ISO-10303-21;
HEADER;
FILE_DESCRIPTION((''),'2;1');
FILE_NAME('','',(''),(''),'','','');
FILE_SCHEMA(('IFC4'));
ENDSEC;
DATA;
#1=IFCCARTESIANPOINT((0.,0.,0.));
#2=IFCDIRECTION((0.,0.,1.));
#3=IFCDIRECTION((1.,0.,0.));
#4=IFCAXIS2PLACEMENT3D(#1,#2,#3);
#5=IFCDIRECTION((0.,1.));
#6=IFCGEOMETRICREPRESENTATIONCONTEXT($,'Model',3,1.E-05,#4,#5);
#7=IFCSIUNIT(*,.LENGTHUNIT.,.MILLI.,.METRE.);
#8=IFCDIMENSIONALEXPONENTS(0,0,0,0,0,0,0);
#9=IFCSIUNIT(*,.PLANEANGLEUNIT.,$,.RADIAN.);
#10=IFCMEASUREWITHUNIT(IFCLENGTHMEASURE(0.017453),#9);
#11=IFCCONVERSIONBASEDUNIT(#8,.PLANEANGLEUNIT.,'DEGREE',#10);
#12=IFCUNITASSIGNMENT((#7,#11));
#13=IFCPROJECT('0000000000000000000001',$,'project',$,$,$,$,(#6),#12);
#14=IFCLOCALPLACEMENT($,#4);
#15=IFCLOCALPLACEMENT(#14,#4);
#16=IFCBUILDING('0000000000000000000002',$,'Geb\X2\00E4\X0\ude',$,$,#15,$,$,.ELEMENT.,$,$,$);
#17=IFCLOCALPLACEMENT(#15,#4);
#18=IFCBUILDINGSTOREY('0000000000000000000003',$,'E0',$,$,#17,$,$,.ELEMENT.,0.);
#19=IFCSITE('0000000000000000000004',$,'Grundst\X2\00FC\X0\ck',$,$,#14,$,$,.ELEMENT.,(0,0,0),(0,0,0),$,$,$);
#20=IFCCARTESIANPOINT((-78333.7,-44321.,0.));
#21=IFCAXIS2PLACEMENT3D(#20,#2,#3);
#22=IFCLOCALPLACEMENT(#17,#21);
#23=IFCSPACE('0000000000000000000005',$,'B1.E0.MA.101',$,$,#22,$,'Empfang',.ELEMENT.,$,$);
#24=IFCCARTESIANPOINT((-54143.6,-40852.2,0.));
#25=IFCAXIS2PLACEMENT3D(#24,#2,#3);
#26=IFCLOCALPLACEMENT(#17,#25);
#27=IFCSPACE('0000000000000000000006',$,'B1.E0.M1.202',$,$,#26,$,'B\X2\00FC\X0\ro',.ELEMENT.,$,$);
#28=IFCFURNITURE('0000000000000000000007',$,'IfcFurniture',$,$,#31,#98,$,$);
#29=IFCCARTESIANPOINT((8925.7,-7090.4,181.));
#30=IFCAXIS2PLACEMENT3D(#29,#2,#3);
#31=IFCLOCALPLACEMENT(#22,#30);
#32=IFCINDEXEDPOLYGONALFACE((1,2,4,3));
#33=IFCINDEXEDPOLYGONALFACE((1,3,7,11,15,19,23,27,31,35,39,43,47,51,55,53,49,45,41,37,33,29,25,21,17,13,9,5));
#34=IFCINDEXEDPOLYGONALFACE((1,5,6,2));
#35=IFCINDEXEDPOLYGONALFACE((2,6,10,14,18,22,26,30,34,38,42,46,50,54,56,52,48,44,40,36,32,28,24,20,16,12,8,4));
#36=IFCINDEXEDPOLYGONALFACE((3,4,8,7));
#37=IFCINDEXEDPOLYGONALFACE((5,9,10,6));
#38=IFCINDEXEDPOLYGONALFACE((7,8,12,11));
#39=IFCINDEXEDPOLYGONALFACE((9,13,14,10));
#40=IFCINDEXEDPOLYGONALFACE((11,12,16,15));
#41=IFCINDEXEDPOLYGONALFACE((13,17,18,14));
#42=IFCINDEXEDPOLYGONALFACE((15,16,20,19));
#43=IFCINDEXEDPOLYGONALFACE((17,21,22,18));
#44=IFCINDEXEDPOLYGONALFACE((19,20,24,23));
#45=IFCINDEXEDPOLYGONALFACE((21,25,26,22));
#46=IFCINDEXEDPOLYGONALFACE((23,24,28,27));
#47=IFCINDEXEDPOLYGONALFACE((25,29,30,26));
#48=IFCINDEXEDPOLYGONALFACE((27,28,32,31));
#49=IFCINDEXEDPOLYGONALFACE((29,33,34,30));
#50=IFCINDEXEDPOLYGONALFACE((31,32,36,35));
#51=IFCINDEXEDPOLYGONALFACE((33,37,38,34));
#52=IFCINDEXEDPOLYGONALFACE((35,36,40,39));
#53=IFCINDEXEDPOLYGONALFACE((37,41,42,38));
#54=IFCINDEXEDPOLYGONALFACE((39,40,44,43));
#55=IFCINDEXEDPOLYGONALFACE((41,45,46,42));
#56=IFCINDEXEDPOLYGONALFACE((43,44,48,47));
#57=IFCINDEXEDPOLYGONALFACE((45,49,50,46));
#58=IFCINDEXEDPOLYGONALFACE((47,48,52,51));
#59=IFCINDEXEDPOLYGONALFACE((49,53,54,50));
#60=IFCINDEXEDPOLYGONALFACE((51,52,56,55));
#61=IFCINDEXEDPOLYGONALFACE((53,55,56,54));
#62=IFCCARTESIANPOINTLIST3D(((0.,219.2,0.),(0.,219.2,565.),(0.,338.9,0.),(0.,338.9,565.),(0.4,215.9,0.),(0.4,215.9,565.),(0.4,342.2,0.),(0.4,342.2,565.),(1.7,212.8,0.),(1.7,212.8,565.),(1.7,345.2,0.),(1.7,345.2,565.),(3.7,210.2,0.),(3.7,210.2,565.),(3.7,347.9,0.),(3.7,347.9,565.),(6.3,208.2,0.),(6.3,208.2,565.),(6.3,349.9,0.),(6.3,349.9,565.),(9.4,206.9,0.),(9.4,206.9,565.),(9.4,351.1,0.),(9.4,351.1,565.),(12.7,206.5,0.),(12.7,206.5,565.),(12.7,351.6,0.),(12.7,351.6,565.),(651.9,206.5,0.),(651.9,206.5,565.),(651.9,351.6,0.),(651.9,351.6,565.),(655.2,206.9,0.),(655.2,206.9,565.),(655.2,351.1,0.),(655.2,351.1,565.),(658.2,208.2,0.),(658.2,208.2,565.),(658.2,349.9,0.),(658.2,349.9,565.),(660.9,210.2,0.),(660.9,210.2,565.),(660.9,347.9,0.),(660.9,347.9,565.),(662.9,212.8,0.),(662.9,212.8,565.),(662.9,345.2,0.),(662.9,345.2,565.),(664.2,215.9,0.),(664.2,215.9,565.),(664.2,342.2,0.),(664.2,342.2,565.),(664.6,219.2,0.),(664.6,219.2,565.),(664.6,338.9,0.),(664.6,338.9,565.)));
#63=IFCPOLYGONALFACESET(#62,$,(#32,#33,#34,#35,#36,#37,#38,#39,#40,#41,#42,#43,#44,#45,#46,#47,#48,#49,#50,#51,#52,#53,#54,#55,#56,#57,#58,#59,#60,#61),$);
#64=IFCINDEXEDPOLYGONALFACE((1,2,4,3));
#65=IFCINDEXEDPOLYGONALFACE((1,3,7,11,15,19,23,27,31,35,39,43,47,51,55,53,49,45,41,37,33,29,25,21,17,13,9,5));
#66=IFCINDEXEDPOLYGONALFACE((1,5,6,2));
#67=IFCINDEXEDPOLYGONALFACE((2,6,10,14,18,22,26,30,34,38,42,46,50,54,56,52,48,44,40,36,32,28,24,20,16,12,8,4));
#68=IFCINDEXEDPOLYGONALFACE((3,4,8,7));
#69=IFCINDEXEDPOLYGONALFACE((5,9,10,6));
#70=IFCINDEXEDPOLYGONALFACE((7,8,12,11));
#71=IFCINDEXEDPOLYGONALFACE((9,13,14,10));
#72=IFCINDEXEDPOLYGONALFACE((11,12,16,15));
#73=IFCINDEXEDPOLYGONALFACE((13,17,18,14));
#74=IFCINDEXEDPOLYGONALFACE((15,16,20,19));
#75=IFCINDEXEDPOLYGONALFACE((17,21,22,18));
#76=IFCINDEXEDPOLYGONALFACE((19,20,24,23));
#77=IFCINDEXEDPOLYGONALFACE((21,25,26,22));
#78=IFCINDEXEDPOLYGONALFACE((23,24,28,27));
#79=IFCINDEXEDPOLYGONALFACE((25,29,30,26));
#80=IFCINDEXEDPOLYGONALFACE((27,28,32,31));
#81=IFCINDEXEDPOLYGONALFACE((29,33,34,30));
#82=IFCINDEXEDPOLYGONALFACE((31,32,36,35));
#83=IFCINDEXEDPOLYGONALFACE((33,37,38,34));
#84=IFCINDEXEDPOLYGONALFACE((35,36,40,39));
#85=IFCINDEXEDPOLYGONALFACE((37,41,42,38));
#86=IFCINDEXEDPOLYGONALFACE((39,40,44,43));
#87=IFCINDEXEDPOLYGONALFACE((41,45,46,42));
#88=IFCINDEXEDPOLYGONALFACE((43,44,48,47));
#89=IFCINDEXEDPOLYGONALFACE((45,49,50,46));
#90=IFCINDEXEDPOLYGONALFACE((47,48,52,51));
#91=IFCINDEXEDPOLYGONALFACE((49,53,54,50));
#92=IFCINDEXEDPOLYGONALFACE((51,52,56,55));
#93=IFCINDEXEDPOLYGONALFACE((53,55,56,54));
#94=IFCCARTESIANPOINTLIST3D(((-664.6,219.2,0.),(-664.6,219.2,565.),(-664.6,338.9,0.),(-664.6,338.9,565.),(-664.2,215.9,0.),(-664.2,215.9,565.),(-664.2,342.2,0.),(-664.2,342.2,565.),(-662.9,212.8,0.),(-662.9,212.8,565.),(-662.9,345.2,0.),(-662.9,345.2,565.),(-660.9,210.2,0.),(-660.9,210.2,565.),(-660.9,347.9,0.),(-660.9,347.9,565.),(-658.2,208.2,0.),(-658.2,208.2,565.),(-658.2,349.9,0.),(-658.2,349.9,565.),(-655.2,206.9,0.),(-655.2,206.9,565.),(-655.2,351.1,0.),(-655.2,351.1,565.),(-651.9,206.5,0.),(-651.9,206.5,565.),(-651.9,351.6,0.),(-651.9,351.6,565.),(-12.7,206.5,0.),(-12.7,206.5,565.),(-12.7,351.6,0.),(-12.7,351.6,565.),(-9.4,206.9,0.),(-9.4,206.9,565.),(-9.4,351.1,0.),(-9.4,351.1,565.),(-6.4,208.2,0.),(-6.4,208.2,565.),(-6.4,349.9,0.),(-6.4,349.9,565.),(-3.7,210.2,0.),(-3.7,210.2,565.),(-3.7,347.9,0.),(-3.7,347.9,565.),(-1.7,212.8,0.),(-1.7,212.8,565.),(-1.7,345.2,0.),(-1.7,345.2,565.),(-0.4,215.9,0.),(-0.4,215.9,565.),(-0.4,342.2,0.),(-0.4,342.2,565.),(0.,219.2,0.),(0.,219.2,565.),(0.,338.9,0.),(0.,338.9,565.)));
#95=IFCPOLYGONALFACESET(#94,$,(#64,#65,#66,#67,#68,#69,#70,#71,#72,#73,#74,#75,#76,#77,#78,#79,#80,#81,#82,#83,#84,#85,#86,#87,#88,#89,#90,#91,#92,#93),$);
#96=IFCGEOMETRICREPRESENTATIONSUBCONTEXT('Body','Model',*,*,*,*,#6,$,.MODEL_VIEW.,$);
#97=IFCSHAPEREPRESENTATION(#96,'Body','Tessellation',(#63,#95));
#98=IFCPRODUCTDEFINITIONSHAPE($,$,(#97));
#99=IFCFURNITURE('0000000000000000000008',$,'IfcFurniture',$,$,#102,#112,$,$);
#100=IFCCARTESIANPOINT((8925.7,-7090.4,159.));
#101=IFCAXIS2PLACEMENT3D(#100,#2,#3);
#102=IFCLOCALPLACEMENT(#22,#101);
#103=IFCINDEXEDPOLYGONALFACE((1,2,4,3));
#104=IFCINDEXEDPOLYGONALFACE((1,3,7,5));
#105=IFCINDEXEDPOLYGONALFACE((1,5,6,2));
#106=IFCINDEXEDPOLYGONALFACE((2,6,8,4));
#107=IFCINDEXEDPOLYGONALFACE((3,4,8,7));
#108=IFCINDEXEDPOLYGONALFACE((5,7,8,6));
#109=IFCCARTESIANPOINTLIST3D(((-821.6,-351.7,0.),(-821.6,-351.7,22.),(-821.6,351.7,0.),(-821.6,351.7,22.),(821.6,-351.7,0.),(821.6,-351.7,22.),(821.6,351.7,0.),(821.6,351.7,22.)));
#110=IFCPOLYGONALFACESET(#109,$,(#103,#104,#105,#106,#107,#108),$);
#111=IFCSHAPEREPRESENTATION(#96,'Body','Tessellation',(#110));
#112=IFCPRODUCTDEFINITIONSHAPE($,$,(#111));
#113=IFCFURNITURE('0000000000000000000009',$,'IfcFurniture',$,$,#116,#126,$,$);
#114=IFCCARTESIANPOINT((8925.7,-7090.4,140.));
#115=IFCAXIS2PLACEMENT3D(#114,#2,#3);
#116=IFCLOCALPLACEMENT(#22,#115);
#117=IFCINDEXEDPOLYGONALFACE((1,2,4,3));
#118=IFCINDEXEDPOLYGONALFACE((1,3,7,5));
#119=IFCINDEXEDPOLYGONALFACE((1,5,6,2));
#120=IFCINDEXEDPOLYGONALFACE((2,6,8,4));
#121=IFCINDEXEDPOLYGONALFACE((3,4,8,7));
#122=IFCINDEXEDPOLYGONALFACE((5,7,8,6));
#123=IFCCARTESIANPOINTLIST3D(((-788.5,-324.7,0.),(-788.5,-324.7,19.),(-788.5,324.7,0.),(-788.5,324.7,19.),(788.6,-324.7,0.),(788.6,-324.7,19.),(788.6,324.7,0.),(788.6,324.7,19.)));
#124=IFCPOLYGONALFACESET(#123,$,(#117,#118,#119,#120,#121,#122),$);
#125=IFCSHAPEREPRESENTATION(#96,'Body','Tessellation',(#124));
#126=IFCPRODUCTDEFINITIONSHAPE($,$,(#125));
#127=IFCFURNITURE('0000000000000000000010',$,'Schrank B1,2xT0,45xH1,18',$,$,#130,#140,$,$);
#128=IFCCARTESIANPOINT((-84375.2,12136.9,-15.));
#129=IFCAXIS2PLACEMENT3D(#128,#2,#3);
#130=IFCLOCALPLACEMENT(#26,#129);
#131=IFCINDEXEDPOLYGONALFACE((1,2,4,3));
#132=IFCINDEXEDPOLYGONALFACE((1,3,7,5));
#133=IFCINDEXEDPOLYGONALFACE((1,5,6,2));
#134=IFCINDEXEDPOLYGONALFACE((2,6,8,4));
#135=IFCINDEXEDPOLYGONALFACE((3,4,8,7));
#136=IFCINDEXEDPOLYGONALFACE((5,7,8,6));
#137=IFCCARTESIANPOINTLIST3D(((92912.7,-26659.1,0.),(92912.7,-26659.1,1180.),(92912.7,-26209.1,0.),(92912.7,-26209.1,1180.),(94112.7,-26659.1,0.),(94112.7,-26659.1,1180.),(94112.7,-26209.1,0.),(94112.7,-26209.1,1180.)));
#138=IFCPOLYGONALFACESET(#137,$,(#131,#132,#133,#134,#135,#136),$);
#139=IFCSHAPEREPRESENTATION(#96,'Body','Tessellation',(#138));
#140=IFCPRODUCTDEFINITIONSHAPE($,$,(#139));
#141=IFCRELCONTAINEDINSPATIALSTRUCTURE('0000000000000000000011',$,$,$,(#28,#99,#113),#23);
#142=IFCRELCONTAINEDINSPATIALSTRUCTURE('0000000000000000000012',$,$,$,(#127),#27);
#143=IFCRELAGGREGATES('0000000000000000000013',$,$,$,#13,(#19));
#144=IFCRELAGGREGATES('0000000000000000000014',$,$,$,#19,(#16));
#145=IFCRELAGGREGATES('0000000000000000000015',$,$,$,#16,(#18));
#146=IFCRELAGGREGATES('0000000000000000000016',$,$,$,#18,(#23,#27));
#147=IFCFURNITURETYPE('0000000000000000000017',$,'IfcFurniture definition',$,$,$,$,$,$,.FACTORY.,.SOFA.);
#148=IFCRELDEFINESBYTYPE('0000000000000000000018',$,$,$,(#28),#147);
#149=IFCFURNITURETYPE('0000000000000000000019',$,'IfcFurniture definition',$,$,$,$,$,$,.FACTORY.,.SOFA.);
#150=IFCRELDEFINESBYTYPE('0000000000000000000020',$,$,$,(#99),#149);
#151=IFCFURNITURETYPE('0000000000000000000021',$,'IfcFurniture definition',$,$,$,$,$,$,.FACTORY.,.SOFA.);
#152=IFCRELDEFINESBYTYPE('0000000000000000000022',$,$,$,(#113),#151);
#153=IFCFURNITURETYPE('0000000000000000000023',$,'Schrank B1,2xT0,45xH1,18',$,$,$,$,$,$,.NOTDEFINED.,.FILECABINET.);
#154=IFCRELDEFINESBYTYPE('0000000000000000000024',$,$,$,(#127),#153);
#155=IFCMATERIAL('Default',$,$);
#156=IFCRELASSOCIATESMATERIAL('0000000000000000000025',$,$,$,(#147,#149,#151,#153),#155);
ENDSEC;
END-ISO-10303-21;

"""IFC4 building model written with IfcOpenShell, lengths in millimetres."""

from ifc_helpers import new_model, entity, si_unit, converted_unit, direction, frame, origin_with_axes, place, context, subcontext, project, spatial, line, arc, indexed_curve, outline, extrude, material, type_object, element, save


model = new_model("IFC4")

# Units and contexts
model_context = context("Model", 3, precision=1e-05, world=origin_with_axes(), true_north=direction((0.0, 1.0)))
body_context = subcontext(model_context, "Body", "Model", "MODEL_VIEW")
ifc_project = project(units=[si_unit("LENGTHUNIT", "METRE", prefix="MILLI"), converted_unit("PLANEANGLEUNIT", "DEGREE", entity("IfcLengthMeasure", 0.017453), si_unit("PLANEANGLEUNIT", "RADIAN"), dimensions=[0, 0, 0, 0, 0, 0, 0])], contexts=[model_context])

# Site, building, storey
site_placement = place(None, origin_with_axes())
site = spatial("IfcSite", under=ifc_project, at=site_placement, Name="Grundstück", CompositionType="ELEMENT", RefLatitude=(0, 0, 0), RefLongitude=(0, 0, 0))
building_placement = place(site_placement, origin_with_axes())
building = spatial("IfcBuilding", under=site, at=building_placement, Name="Gebäude", CompositionType="ELEMENT")
storey_placement = place(building_placement, origin_with_axes())
storey = spatial("IfcBuildingStorey", under=building, at=storey_placement, Name="E0", CompositionType="ELEMENT", Elevation=0.0)

# Shared definitions
space_1_placement = place(storey_placement, frame((-78333.7, -44321.0, 0.0), z_axis=(0.0, 0.0, 1.0), x_axis=(1.0, 0.0, 0.0)))
space_1 = spatial("IfcSpace", under=storey, at=space_1_placement, Name="B1.E0.MA.101", LongName="Empfang", CompositionType="ELEMENT")

# Furniture
ifc_material_1 = material(Name="Default")
furniture_type_1 = type_object("IfcFurnitureType", Name="IfcFurniture definition", AssemblyPlace="FACTORY", PredefinedType="SOFA", material=ifc_material_1)
furniture_1_placement = place(space_1_placement, frame((8925.7, -7090.4, 181.0), z_axis=(0.0, 0.0, 1.0), x_axis=(1.0, 0.0, 0.0)))
element("IfcFurniture", 1, at=furniture_1_placement, inside=space_1, type_object=furniture_type_1, Name="IfcFurniture", context=body_context, shape_type="SweptSolid", body=[
    extrude(outline(indexed_curve([(651.9, 351.6), (660.9, 347.9), (664.6, 338.9), (664.6, 219.2), (660.9, 210.2), (651.9, 206.5), (12.7, 206.5), (3.7, 210.2), (0.0, 219.2), (0.0, 338.9), (3.7, 347.9), (12.7, 351.6)], segments=[arc(1, 2, 3), line(3, 4), arc(4, 5, 6), line(6, 7), arc(7, 8, 9), line(9, 10), arc(10, 11, 12), line(12, 1)])), origin_with_axes(), (0.0, 0.0, 1.0), 565.0),
    extrude(outline(indexed_curve([(-651.9, 351.6), (-660.9, 347.9), (-664.6, 338.9), (-664.6, 219.2), (-660.9, 210.2), (-651.9, 206.5), (-12.7, 206.5), (-3.7, 210.2), (0.0, 219.2), (0.0, 338.9), (-3.7, 347.9), (-12.7, 351.6)], segments=[arc(1, 2, 3), line(3, 4), arc(4, 5, 6), line(6, 7), arc(7, 8, 9), line(9, 10), arc(10, 11, 12), line(12, 1)])), origin_with_axes(), (0.0, 0.0, 1.0), 565.0),
])
furniture_type_2 = type_object("IfcFurnitureType", Name="IfcFurniture definition", AssemblyPlace="FACTORY", PredefinedType="SOFA", material=ifc_material_1)
furniture_2_placement = place(space_1_placement, frame((8925.7, -7090.4, 159.0), z_axis=(0.0, 0.0, 1.0), x_axis=(1.0, 0.0, 0.0)))
element("IfcFurniture", 2, at=furniture_2_placement, inside=space_1, type_object=furniture_type_2, Name="IfcFurniture", context=body_context, shape_type="SweptSolid", body=[
    extrude(outline(indexed_curve([(-821.6, -351.7), (-821.6, 351.7), (821.6, 351.7), (821.6, -351.7)], segments=[line(1, 2), line(2, 3), line(3, 4), line(4, 1)])), origin_with_axes(), (0.0, 0.0, 1.0), 22.0),
])
furniture_type_3 = type_object("IfcFurnitureType", Name="IfcFurniture definition", AssemblyPlace="FACTORY", PredefinedType="SOFA", material=ifc_material_1)
furniture_3_placement = place(space_1_placement, frame((8925.7, -7090.4, 140.0), z_axis=(0.0, 0.0, 1.0), x_axis=(1.0, 0.0, 0.0)))
element("IfcFurniture", 3, at=furniture_3_placement, inside=space_1, type_object=furniture_type_3, Name="IfcFurniture", context=body_context, shape_type="SweptSolid", body=[
    extrude(outline(indexed_curve([(-788.5, -324.7), (-788.5, 324.7), (788.6, 324.7), (788.6, -324.7)], segments=[line(1, 2), line(2, 3), line(3, 4), line(4, 1)])), origin_with_axes(), (0.0, 0.0, 1.0), 19.0),
])

# Shared definitions
space_2_placement = place(storey_placement, frame((-54143.6, -40852.2, 0.0), z_axis=(0.0, 0.0, 1.0), x_axis=(1.0, 0.0, 0.0)))
space_2 = spatial("IfcSpace", under=storey, at=space_2_placement, Name="B1.E0.M1.202", LongName="Büro", CompositionType="ELEMENT")

# Furniture
furniture_type_4 = type_object("IfcFurnitureType", Name="Schrank B1,2xT0,45xH1,18", AssemblyPlace="NOTDEFINED", PredefinedType="FILECABINET", material=ifc_material_1)
furniture_4_placement = place(space_2_placement, frame((-84375.2, 12136.9, -15.0), z_axis=(0.0, 0.0, 1.0), x_axis=(1.0, 0.0, 0.0)))
element("IfcFurniture", 4, at=furniture_4_placement, inside=space_2, type_object=furniture_type_4, Name="Schrank B1,2xT0,45xH1,18", context=body_context, shape_type="SweptSolid", body=[
    extrude(outline(indexed_curve([(92912.7, -26659.1), (94112.7, -26659.1), (94112.7, -26209.1), (92912.7, -26209.1)], segments=[line(1, 2), line(2, 3), line(3, 4), line(4, 1)])), origin_with_axes(), (0.0, 0.0, 1.0), 1180.0),
])

save(model, "model.ifc")
